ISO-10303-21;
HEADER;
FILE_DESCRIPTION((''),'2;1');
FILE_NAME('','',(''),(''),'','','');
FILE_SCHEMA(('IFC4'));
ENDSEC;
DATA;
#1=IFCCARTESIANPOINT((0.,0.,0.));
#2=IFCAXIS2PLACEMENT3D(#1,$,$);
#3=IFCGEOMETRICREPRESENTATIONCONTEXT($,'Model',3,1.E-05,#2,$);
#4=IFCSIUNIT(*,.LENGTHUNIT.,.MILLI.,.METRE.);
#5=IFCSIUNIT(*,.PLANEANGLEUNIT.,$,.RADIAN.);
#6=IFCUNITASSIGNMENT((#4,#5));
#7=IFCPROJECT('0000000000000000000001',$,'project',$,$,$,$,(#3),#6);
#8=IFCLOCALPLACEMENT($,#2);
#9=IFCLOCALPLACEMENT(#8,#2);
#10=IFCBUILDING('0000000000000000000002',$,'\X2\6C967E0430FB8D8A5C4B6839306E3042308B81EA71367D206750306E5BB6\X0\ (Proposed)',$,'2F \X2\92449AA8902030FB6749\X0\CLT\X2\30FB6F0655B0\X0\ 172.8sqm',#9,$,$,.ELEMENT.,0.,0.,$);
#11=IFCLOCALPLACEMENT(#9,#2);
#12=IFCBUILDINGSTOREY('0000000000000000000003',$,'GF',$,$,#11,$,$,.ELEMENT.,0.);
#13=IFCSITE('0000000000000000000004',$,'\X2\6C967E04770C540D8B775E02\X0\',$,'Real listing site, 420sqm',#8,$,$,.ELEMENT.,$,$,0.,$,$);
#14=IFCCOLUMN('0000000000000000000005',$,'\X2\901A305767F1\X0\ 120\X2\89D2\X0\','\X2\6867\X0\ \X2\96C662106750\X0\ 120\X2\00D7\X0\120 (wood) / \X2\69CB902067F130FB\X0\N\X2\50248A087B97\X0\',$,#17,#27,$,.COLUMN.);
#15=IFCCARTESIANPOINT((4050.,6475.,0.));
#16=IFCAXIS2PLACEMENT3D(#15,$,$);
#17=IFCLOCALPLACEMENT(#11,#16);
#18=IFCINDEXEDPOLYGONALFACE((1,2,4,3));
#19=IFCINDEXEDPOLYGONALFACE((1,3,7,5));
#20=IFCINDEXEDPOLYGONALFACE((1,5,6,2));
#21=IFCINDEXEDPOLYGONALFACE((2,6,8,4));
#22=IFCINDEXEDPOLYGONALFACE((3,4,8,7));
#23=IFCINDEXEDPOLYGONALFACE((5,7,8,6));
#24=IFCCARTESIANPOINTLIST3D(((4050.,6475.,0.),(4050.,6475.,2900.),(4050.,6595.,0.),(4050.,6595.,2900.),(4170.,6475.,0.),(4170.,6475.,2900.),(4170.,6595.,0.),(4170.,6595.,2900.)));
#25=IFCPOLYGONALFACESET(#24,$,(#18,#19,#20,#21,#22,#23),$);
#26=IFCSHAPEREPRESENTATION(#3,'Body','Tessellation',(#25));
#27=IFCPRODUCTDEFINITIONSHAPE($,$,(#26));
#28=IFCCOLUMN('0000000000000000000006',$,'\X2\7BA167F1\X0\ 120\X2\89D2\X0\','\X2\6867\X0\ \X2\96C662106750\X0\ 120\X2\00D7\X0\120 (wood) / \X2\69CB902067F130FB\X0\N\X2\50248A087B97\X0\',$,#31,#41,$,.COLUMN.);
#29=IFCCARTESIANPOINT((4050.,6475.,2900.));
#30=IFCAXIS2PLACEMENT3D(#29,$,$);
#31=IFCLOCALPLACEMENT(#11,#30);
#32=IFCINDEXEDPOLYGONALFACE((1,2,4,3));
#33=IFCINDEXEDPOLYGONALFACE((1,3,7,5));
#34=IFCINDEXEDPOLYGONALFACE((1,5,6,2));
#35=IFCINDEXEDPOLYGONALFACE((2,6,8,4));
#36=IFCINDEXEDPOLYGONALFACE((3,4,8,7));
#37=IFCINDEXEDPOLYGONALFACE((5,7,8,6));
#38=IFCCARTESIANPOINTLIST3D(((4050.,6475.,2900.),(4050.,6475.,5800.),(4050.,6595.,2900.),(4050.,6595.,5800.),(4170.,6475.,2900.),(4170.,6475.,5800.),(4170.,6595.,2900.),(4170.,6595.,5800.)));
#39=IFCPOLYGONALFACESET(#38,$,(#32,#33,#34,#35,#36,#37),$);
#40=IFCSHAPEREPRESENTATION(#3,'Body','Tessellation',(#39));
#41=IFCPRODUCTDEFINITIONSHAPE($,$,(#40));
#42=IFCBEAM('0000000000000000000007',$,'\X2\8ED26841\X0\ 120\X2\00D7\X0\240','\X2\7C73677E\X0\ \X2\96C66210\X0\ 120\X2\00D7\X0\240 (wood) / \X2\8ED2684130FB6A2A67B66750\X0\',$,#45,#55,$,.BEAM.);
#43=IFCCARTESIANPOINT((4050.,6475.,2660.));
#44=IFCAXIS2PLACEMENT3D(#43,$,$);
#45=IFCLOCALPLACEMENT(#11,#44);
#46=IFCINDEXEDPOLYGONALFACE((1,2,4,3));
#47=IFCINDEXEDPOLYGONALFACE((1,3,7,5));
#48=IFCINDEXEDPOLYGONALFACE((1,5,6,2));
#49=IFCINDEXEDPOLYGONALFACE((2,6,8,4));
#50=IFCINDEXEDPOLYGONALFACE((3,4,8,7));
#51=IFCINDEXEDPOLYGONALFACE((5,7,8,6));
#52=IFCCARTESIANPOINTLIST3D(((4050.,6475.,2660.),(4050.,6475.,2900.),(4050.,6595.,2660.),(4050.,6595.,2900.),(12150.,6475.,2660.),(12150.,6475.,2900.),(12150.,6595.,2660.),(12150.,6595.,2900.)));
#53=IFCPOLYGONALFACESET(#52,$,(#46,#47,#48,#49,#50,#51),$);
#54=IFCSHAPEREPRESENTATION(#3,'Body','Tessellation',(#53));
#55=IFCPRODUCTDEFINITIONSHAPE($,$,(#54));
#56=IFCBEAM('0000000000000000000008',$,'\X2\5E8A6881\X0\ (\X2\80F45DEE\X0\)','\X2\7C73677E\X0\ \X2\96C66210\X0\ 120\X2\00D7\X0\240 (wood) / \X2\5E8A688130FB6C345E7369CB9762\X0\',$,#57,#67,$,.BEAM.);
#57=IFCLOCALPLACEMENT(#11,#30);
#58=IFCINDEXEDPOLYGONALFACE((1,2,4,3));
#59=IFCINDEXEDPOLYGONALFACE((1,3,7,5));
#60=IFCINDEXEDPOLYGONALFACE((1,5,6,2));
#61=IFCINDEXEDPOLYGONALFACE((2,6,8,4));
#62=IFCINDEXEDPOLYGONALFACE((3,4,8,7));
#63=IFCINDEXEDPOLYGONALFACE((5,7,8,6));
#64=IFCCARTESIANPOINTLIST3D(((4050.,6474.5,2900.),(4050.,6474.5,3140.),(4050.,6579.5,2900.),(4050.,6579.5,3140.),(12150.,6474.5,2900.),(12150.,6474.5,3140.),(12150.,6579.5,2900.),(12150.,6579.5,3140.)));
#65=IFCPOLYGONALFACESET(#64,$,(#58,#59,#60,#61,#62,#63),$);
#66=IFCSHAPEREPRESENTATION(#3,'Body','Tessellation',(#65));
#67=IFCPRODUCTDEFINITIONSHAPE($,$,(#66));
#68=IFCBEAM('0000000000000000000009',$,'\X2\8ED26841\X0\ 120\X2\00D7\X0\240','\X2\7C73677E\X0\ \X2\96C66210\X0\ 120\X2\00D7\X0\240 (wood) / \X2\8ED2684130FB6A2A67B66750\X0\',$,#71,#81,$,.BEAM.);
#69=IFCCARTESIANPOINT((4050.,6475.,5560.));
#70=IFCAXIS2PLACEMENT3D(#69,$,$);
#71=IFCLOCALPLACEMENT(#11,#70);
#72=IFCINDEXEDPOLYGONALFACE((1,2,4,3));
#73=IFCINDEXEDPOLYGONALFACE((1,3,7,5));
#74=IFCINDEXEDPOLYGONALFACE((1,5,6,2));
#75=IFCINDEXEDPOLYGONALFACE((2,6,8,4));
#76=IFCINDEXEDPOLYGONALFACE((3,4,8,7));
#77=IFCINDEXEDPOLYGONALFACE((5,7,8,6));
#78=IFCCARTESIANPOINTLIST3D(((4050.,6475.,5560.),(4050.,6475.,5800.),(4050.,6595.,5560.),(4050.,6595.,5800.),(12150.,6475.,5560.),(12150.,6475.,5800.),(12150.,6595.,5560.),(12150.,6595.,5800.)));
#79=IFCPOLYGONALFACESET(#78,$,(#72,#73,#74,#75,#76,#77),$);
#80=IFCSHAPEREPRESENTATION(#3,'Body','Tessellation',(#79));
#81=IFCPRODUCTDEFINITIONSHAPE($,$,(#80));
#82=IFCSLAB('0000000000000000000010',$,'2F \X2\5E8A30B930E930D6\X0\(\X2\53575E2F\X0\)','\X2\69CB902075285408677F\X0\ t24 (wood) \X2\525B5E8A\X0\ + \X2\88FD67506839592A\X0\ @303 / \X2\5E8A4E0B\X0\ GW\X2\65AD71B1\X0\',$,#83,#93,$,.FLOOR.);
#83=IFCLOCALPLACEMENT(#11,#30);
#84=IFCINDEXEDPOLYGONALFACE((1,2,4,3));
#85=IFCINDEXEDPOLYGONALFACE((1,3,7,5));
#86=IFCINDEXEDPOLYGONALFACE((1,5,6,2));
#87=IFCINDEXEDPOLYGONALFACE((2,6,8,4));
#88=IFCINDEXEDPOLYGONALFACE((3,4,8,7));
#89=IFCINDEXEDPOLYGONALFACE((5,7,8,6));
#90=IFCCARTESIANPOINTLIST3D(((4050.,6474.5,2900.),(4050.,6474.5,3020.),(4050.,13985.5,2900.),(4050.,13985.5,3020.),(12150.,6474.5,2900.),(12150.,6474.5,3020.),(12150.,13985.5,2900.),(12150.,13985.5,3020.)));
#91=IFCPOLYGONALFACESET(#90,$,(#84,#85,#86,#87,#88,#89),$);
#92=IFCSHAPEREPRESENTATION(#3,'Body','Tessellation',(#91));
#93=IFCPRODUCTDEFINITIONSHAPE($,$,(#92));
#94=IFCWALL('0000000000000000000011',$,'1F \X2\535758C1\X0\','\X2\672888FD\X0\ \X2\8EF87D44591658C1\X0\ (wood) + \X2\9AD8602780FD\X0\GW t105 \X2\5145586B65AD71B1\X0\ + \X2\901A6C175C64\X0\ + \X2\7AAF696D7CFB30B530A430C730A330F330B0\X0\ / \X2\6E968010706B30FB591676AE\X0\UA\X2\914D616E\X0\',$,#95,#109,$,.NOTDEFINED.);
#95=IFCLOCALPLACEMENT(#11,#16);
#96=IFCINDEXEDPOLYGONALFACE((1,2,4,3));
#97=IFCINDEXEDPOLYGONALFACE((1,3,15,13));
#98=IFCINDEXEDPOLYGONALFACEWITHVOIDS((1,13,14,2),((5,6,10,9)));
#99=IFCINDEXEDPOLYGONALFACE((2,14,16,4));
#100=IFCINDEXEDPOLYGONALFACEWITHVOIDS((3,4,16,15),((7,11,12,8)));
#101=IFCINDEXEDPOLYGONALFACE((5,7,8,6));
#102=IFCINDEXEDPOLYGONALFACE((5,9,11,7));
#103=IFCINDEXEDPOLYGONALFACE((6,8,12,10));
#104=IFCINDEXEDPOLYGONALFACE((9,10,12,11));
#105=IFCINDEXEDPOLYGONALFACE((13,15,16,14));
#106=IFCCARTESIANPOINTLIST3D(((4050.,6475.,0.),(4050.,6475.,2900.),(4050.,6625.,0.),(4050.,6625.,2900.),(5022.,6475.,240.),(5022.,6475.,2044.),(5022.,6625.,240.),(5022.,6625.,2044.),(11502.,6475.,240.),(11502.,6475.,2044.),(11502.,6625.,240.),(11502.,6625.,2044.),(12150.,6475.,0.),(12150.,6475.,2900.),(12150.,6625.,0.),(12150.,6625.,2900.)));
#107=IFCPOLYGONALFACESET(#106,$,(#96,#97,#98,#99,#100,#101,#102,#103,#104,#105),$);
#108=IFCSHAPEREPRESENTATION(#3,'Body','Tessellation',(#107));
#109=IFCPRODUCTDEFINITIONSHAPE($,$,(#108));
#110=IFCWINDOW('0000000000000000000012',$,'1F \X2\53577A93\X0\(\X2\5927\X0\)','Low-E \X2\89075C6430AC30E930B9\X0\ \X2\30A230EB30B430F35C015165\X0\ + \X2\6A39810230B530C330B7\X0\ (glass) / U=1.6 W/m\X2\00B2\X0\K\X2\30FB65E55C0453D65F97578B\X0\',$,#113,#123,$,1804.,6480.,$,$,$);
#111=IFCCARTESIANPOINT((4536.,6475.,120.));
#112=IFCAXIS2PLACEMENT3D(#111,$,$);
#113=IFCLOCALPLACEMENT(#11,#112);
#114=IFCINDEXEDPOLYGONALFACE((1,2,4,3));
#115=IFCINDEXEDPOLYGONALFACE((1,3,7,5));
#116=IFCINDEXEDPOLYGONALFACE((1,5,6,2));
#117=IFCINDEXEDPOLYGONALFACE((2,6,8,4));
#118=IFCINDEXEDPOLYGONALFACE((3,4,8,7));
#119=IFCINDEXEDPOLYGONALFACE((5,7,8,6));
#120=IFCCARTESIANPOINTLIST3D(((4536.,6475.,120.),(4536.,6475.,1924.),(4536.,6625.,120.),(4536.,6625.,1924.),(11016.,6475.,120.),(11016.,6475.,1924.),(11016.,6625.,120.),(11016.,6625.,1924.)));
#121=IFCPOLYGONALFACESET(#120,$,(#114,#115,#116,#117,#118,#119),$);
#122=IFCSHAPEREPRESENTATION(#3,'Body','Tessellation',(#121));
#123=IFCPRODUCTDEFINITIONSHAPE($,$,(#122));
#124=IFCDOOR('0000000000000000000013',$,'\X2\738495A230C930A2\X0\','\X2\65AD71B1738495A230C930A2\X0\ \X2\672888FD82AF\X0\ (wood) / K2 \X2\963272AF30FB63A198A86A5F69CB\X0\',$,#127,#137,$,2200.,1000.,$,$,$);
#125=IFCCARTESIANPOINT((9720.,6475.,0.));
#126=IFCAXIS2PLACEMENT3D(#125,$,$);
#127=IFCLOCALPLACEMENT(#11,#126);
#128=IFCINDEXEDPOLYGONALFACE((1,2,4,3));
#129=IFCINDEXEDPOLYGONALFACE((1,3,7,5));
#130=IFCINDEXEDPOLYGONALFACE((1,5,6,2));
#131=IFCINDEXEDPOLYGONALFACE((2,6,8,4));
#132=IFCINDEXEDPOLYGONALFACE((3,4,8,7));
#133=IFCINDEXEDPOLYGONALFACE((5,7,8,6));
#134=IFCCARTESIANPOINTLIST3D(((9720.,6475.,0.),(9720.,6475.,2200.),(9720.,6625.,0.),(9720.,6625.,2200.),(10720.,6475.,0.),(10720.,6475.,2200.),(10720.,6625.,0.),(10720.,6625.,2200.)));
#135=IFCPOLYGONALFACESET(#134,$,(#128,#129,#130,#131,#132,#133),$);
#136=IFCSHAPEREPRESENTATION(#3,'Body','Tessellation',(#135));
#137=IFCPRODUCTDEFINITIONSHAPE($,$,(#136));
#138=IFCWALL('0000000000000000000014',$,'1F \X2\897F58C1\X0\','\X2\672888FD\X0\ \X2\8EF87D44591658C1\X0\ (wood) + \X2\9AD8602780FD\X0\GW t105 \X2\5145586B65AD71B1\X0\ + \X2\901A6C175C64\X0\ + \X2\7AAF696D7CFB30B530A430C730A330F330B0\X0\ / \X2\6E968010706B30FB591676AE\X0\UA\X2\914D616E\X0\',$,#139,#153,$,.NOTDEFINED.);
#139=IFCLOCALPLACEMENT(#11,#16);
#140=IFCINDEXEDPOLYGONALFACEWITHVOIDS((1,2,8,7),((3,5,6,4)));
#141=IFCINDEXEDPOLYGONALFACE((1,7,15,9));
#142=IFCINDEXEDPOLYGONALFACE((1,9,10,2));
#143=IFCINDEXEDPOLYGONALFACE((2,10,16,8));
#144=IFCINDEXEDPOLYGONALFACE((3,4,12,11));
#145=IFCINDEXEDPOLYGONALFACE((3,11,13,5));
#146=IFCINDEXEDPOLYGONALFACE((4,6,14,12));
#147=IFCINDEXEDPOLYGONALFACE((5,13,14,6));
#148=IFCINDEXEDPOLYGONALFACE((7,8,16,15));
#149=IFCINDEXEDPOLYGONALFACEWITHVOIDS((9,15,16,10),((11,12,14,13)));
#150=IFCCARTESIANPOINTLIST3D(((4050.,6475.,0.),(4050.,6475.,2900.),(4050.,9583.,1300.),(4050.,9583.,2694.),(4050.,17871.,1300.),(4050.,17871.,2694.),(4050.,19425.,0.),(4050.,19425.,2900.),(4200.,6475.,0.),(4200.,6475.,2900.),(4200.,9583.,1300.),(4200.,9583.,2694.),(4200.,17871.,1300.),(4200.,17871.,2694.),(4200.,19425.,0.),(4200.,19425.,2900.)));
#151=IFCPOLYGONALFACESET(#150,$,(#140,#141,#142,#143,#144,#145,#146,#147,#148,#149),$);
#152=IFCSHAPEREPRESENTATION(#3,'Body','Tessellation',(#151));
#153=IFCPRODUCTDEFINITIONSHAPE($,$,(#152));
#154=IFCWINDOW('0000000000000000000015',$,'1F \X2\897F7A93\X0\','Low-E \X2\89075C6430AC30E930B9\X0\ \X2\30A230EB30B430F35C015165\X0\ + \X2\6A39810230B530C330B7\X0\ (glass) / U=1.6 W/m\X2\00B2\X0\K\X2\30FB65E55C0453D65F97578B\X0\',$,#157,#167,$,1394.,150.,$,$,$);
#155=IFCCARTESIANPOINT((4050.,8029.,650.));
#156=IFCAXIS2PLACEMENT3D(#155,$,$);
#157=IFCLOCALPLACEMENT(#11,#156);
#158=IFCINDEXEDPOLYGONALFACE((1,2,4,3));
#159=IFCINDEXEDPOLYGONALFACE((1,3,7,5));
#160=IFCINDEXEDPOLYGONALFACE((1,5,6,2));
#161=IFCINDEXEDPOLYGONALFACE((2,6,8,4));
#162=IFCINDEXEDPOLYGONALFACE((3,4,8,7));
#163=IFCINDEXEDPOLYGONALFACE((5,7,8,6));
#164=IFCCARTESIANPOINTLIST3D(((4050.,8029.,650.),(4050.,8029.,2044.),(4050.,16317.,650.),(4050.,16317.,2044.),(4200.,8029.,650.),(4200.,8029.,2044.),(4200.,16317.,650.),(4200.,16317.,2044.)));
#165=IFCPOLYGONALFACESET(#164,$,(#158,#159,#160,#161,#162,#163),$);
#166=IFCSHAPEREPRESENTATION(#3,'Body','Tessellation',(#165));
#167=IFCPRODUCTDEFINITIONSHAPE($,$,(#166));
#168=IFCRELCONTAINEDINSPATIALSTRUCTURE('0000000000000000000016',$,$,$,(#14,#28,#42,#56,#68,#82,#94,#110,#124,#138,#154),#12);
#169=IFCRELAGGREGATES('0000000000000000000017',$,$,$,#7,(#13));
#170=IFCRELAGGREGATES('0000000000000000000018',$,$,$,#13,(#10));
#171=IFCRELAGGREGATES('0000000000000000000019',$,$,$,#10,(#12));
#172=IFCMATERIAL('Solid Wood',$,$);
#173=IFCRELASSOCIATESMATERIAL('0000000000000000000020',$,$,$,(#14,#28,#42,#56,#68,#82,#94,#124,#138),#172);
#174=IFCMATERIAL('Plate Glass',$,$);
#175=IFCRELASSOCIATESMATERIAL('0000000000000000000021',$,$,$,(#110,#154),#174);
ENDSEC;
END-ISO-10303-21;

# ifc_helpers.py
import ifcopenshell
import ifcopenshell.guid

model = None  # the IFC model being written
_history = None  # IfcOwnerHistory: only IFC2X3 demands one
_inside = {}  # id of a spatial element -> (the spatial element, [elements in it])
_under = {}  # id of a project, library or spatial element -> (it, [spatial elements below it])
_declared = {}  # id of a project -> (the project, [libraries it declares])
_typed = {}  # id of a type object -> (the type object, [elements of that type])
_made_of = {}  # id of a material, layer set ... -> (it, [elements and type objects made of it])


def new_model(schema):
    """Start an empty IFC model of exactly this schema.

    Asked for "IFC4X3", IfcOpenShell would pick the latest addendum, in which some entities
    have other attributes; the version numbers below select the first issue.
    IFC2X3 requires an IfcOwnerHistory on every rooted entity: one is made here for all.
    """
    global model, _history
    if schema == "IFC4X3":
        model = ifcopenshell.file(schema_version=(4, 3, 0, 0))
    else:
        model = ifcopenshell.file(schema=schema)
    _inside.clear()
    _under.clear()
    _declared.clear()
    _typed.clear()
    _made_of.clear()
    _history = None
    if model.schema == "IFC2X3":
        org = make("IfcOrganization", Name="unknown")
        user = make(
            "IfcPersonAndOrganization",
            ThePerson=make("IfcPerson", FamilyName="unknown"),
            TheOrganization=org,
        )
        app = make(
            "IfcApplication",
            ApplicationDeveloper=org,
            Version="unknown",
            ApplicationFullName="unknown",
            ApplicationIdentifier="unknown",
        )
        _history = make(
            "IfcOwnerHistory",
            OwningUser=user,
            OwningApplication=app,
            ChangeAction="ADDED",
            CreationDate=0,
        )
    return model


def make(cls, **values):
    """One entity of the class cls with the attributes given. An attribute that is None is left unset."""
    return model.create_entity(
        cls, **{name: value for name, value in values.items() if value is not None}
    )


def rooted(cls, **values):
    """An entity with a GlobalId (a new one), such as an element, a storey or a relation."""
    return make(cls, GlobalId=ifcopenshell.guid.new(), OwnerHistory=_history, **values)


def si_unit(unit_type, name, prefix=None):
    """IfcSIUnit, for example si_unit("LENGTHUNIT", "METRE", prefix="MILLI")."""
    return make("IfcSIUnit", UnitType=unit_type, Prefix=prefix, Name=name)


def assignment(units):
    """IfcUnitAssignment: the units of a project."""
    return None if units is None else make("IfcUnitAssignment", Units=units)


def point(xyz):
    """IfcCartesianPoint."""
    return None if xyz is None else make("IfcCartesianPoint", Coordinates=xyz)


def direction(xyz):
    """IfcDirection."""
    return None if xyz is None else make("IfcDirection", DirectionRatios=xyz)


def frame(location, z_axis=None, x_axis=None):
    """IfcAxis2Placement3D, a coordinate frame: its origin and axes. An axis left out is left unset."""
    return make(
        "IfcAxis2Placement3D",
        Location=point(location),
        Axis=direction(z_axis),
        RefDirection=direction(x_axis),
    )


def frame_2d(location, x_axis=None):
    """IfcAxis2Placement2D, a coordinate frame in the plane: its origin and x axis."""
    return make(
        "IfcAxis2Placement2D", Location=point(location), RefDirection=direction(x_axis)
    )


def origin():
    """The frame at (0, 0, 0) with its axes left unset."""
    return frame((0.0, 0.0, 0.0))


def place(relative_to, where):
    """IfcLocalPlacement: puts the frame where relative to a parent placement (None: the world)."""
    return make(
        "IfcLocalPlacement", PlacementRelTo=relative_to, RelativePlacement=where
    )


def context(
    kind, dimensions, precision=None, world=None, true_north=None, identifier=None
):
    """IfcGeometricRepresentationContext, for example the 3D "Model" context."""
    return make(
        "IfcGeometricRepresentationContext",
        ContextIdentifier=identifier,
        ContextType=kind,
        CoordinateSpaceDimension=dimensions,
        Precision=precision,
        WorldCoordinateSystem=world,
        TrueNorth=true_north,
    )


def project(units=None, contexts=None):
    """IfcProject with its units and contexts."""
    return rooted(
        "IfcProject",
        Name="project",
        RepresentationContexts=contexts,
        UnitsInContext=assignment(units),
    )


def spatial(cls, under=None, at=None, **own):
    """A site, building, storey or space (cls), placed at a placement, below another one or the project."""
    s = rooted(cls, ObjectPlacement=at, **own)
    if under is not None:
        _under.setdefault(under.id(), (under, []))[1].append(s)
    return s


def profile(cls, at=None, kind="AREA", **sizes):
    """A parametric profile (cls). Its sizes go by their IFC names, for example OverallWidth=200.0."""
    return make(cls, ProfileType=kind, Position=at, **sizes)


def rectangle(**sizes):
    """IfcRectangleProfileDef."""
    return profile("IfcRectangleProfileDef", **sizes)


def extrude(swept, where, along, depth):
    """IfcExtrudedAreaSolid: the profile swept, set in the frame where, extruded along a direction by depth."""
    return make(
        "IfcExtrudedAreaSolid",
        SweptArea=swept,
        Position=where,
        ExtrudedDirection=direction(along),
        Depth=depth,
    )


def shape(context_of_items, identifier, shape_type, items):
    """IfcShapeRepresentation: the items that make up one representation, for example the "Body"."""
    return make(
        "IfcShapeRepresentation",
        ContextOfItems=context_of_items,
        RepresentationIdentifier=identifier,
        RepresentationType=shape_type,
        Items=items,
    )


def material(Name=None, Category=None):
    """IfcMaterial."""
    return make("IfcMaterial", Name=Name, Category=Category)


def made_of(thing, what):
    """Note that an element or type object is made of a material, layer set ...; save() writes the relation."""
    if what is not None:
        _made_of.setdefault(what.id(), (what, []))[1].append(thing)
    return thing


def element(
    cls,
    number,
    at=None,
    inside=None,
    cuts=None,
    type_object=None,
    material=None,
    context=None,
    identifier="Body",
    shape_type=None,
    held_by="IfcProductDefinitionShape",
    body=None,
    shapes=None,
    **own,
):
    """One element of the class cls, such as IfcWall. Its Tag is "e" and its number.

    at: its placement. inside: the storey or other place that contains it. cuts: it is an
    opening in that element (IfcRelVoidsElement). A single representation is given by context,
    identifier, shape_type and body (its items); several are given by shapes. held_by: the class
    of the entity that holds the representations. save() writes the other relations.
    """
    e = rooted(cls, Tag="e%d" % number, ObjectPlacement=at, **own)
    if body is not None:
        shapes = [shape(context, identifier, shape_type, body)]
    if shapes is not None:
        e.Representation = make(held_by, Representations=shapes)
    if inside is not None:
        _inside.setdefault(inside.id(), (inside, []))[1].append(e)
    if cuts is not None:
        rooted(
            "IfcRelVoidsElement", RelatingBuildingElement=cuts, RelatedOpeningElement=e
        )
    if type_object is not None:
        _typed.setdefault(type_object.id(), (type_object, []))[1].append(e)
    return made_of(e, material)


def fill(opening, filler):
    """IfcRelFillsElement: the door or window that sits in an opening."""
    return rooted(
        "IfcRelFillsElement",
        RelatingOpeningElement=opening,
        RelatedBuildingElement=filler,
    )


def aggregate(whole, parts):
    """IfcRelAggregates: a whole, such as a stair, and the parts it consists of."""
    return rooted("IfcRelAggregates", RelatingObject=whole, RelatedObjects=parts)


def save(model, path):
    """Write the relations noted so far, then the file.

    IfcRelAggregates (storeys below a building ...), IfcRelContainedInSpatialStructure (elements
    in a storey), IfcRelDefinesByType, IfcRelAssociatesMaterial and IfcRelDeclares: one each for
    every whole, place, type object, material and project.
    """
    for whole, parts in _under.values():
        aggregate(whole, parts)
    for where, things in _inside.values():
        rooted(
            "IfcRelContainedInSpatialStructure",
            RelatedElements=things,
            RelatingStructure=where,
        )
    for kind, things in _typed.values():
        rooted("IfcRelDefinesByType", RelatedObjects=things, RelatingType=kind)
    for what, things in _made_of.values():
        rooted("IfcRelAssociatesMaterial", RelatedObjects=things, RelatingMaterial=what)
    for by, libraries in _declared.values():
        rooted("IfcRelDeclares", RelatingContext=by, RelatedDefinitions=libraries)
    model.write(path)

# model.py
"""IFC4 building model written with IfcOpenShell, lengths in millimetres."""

from ifc_helpers import new_model, si_unit, frame, frame_2d, origin, place, context, project, spatial, rectangle, extrude, material, element, fill, save


model = new_model("IFC4")

# Units and contexts
model_context = context("Model", 3, precision=1e-05, world=origin())
ifc_project = project(units=[si_unit("LENGTHUNIT", "METRE", prefix="MILLI"), si_unit("PLANEANGLEUNIT", "RADIAN")], contexts=[model_context])

# Site, building, storey
site_placement = place(None, origin())
site = spatial("IfcSite", under=ifc_project, at=site_placement, Name="沖縄県名護市", ObjectType="Real listing site, 420sqm", CompositionType="ELEMENT", RefElevation=0.0)
building_placement = place(site_placement, origin())
building = spatial("IfcBuilding", under=site, at=building_placement, Name="沖縄・越屋根のある自然素材の家 (Proposed)", ObjectType="2F 鉄骨造・杉CLT・漆喰 172.8sqm", CompositionType="ELEMENT", ElevationOfRefHeight=0.0, ElevationOfTerrain=0.0)
storey_placement = place(building_placement, origin())
storey = spatial("IfcBuildingStorey", under=building, at=storey_placement, Name="GF", CompositionType="ELEMENT", Elevation=0.0)

# Columns
ifc_material_1 = material(Name="Solid Wood")
column_1_placement = place(storey_placement, frame((4050.0, 6475.0, 0.0)))
element("IfcColumn", 1, at=column_1_placement, inside=storey, material=ifc_material_1, Name="通し柱 120角", Description="桧 集成材 120×120 (wood) / 構造柱・N値計算", PredefinedType="COLUMN", context=model_context, shape_type="SweptSolid", body=[
    extrude(rectangle(XDim=120.0, YDim=120.0, at=frame_2d((60.0, 60.0))), frame((4050.0, 6475.0, 0.0)), (0.0, 0.0, 1.0), 2900.0),
])
column_2_placement = place(storey_placement, frame((4050.0, 6475.0, 2900.0)))
element("IfcColumn", 2, at=column_2_placement, inside=storey, material=ifc_material_1, Name="管柱 120角", Description="桧 集成材 120×120 (wood) / 構造柱・N値計算", PredefinedType="COLUMN", context=model_context, shape_type="SweptSolid", body=[
    extrude(rectangle(XDim=120.0, YDim=120.0, at=frame_2d((60.0, 60.0))), frame((4050.0, 6475.0, 2900.0)), (0.0, 0.0, 1.0), 2900.0),
])

# Beams
beam_1_placement = place(storey_placement, frame((4050.0, 6475.0, 2660.0)))
element("IfcBeam", 3, at=beam_1_placement, inside=storey, material=ifc_material_1, Name="軒桁 120×240", Description="米松 集成 120×240 (wood) / 軒桁・横架材", PredefinedType="BEAM", context=model_context, shape_type="SweptSolid", body=[
    extrude(rectangle(XDim=8100.0, YDim=120.0, at=frame_2d((4050.0, 60.0))), frame((4050.0, 6475.0, 2660.0)), (0.0, 0.0, 1.0), 240.0),
])
beam_2_placement = place(storey_placement, frame((4050.0, 6475.0, 2900.0)))
element("IfcBeam", 4, at=beam_2_placement, inside=storey, material=ifc_material_1, Name="床梁 (胴差)", Description="米松 集成 120×240 (wood) / 床梁・水平構面", PredefinedType="BEAM", context=model_context, shape_type="SweptSolid", body=[
    extrude(rectangle(XDim=8100.0, YDim=105.0, at=frame_2d((4050.0, 52.0))), frame((4050.0, 6475.0, 2900.0)), (0.0, 0.0, 1.0), 240.0),
])
beam_3_placement = place(storey_placement, frame((4050.0, 6475.0, 5560.0)))
element("IfcBeam", 5, at=beam_3_placement, inside=storey, material=ifc_material_1, Name="軒桁 120×240", Description="米松 集成 120×240 (wood) / 軒桁・横架材", PredefinedType="BEAM", context=model_context, shape_type="SweptSolid", body=[
    extrude(rectangle(XDim=8100.0, YDim=120.0, at=frame_2d((4050.0, 60.0))), frame((4050.0, 6475.0, 5560.0)), (0.0, 0.0, 1.0), 240.0),
])

# Slab
slab_1_placement = place(storey_placement, frame((4050.0, 6475.0, 2900.0)))
element("IfcSlab", 6, at=slab_1_placement, inside=storey, material=ifc_material_1, Name="2F 床スラブ(南帯)", Description="構造用合板 t24 (wood) 剛床 + 製材根太 @303 / 床下 GW断熱", PredefinedType="FLOOR", context=model_context, shape_type="SweptSolid", body=[
    extrude(rectangle(XDim=8100.0, YDim=7511.0, at=frame_2d((4050.0, 3755.0))), frame((4050.0, 6475.0, 2900.0)), (0.0, 0.0, 1.0), 120.0),
])

# Wall, openings, window, door
wall_1_placement = place(storey_placement, frame((4050.0, 6475.0, 0.0)))
wall_1 = element("IfcWall", 7, at=wall_1_placement, inside=storey, material=ifc_material_1, Name="1F 南壁", Description="木製 軸組外壁 (wood) + 高性能GW t105 充填断熱 + 通気層 + 窯業系サイディング / 準耐火・外皮UA配慮", PredefinedType="NOTDEFINED", context=model_context, shape_type="SweptSolid", body=[
    extrude(rectangle(XDim=8100.0, YDim=150.0, at=frame_2d((4050.0, 75.0))), frame((4050.0, 6475.0, 0.0)), (0.0, 0.0, 1.0), 2900.0),
])
opening_1_placement = place(storey_placement, frame((4536.0, 6475.0, 120.0)))
opening_1 = element("IfcOpeningElement", 8, at=opening_1_placement, cuts=wall_1, PredefinedType="NOTDEFINED", context=model_context, shape_type="SweptSolid", body=[
    extrude(rectangle(XDim=6480.0, YDim=150.0, at=frame_2d((3240.0, 75.0))), frame((4536.0, 6475.0, 120.0)), (0.0, 0.0, 1.0), 1804.0),
])
opening_2_placement = place(storey_placement, frame((9720.0, 6475.0, 0.0)))
opening_2 = element("IfcOpeningElement", 9, at=opening_2_placement, cuts=wall_1, PredefinedType="NOTDEFINED", context=model_context, shape_type="SweptSolid", body=[
    extrude(rectangle(XDim=1000.0, YDim=150.0, at=frame_2d((500.0, 75.0))), frame((9720.0, 6475.0, 0.0)), (0.0, 0.0, 1.0), 2200.0),
])
ifc_material_2 = material(Name="Plate Glass")
window_1_placement = place(storey_placement, frame((4536.0, 6475.0, 120.0)))
window_1 = element("IfcWindow", 10, at=window_1_placement, inside=storey, material=ifc_material_2, Name="1F 南窓(大)", Description="Low-E 複層ガラス アルゴン封入 + 樹脂サッシ (glass) / U=1.6 W/m²K・日射取得型", OverallHeight=1804.0, OverallWidth=6480.0, context=model_context, shape_type="SweptSolid", body=[
    extrude(rectangle(XDim=6480.0, YDim=150.0, at=frame_2d((3240.0, 75.0))), frame((4536.0, 6475.0, 120.0)), (0.0, 0.0, 1.0), 1804.0),
])
fill(opening_1, window_1)
door_placement = place(storey_placement, frame((9720.0, 6475.0, 0.0)))
door = element("IfcDoor", 11, at=door_placement, inside=storey, material=ifc_material_1, Name="玄関ドア", Description="断熱玄関ドア 木製芯 (wood) / K2 防犯・採風機構", OverallHeight=2200.0, OverallWidth=1000.0, context=model_context, shape_type="SweptSolid", body=[
    extrude(rectangle(XDim=1000.0, YDim=150.0, at=frame_2d((500.0, 75.0))), frame((9720.0, 6475.0, 0.0)), (0.0, 0.0, 1.0), 2200.0),
])
fill(opening_2, door)

# Wall, opening, window
wall_2_placement = place(storey_placement, frame((4050.0, 6475.0, 0.0)))
wall_2 = element("IfcWall", 12, at=wall_2_placement, inside=storey, material=ifc_material_1, Name="1F 西壁", Description="木製 軸組外壁 (wood) + 高性能GW t105 充填断熱 + 通気層 + 窯業系サイディング / 準耐火・外皮UA配慮", PredefinedType="NOTDEFINED", context=model_context, shape_type="SweptSolid", body=[
    extrude(rectangle(XDim=150.0, YDim=12950.0, at=frame_2d((75.0, 6475.0))), frame((4050.0, 6475.0, 0.0)), (0.0, 0.0, 1.0), 2900.0),
])
opening_3_placement = place(storey_placement, frame((4050.0, 8029.0, 650.0)))
opening_3 = element("IfcOpeningElement", 13, at=opening_3_placement, cuts=wall_2, PredefinedType="NOTDEFINED", context=model_context, shape_type="SweptSolid", body=[
    extrude(rectangle(XDim=150.0, YDim=8288.0, at=frame_2d((75.0, 4144.0))), frame((4050.0, 8029.0, 650.0)), (0.0, 0.0, 1.0), 1394.0),
])
window_2_placement = place(storey_placement, frame((4050.0, 8029.0, 650.0)))
window_2 = element("IfcWindow", 14, at=window_2_placement, inside=storey, material=ifc_material_2, Name="1F 西窓", Description="Low-E 複層ガラス アルゴン封入 + 樹脂サッシ (glass) / U=1.6 W/m²K・日射取得型", OverallHeight=1394.0, OverallWidth=150.0, context=model_context, shape_type="SweptSolid", body=[
    extrude(rectangle(XDim=150.0, YDim=8288.0, at=frame_2d((75.0, 4144.0))), frame((4050.0, 8029.0, 650.0)), (0.0, 0.0, 1.0), 1394.0),
])
fill(opening_3, window_2)

save(model, "model.ifc")
